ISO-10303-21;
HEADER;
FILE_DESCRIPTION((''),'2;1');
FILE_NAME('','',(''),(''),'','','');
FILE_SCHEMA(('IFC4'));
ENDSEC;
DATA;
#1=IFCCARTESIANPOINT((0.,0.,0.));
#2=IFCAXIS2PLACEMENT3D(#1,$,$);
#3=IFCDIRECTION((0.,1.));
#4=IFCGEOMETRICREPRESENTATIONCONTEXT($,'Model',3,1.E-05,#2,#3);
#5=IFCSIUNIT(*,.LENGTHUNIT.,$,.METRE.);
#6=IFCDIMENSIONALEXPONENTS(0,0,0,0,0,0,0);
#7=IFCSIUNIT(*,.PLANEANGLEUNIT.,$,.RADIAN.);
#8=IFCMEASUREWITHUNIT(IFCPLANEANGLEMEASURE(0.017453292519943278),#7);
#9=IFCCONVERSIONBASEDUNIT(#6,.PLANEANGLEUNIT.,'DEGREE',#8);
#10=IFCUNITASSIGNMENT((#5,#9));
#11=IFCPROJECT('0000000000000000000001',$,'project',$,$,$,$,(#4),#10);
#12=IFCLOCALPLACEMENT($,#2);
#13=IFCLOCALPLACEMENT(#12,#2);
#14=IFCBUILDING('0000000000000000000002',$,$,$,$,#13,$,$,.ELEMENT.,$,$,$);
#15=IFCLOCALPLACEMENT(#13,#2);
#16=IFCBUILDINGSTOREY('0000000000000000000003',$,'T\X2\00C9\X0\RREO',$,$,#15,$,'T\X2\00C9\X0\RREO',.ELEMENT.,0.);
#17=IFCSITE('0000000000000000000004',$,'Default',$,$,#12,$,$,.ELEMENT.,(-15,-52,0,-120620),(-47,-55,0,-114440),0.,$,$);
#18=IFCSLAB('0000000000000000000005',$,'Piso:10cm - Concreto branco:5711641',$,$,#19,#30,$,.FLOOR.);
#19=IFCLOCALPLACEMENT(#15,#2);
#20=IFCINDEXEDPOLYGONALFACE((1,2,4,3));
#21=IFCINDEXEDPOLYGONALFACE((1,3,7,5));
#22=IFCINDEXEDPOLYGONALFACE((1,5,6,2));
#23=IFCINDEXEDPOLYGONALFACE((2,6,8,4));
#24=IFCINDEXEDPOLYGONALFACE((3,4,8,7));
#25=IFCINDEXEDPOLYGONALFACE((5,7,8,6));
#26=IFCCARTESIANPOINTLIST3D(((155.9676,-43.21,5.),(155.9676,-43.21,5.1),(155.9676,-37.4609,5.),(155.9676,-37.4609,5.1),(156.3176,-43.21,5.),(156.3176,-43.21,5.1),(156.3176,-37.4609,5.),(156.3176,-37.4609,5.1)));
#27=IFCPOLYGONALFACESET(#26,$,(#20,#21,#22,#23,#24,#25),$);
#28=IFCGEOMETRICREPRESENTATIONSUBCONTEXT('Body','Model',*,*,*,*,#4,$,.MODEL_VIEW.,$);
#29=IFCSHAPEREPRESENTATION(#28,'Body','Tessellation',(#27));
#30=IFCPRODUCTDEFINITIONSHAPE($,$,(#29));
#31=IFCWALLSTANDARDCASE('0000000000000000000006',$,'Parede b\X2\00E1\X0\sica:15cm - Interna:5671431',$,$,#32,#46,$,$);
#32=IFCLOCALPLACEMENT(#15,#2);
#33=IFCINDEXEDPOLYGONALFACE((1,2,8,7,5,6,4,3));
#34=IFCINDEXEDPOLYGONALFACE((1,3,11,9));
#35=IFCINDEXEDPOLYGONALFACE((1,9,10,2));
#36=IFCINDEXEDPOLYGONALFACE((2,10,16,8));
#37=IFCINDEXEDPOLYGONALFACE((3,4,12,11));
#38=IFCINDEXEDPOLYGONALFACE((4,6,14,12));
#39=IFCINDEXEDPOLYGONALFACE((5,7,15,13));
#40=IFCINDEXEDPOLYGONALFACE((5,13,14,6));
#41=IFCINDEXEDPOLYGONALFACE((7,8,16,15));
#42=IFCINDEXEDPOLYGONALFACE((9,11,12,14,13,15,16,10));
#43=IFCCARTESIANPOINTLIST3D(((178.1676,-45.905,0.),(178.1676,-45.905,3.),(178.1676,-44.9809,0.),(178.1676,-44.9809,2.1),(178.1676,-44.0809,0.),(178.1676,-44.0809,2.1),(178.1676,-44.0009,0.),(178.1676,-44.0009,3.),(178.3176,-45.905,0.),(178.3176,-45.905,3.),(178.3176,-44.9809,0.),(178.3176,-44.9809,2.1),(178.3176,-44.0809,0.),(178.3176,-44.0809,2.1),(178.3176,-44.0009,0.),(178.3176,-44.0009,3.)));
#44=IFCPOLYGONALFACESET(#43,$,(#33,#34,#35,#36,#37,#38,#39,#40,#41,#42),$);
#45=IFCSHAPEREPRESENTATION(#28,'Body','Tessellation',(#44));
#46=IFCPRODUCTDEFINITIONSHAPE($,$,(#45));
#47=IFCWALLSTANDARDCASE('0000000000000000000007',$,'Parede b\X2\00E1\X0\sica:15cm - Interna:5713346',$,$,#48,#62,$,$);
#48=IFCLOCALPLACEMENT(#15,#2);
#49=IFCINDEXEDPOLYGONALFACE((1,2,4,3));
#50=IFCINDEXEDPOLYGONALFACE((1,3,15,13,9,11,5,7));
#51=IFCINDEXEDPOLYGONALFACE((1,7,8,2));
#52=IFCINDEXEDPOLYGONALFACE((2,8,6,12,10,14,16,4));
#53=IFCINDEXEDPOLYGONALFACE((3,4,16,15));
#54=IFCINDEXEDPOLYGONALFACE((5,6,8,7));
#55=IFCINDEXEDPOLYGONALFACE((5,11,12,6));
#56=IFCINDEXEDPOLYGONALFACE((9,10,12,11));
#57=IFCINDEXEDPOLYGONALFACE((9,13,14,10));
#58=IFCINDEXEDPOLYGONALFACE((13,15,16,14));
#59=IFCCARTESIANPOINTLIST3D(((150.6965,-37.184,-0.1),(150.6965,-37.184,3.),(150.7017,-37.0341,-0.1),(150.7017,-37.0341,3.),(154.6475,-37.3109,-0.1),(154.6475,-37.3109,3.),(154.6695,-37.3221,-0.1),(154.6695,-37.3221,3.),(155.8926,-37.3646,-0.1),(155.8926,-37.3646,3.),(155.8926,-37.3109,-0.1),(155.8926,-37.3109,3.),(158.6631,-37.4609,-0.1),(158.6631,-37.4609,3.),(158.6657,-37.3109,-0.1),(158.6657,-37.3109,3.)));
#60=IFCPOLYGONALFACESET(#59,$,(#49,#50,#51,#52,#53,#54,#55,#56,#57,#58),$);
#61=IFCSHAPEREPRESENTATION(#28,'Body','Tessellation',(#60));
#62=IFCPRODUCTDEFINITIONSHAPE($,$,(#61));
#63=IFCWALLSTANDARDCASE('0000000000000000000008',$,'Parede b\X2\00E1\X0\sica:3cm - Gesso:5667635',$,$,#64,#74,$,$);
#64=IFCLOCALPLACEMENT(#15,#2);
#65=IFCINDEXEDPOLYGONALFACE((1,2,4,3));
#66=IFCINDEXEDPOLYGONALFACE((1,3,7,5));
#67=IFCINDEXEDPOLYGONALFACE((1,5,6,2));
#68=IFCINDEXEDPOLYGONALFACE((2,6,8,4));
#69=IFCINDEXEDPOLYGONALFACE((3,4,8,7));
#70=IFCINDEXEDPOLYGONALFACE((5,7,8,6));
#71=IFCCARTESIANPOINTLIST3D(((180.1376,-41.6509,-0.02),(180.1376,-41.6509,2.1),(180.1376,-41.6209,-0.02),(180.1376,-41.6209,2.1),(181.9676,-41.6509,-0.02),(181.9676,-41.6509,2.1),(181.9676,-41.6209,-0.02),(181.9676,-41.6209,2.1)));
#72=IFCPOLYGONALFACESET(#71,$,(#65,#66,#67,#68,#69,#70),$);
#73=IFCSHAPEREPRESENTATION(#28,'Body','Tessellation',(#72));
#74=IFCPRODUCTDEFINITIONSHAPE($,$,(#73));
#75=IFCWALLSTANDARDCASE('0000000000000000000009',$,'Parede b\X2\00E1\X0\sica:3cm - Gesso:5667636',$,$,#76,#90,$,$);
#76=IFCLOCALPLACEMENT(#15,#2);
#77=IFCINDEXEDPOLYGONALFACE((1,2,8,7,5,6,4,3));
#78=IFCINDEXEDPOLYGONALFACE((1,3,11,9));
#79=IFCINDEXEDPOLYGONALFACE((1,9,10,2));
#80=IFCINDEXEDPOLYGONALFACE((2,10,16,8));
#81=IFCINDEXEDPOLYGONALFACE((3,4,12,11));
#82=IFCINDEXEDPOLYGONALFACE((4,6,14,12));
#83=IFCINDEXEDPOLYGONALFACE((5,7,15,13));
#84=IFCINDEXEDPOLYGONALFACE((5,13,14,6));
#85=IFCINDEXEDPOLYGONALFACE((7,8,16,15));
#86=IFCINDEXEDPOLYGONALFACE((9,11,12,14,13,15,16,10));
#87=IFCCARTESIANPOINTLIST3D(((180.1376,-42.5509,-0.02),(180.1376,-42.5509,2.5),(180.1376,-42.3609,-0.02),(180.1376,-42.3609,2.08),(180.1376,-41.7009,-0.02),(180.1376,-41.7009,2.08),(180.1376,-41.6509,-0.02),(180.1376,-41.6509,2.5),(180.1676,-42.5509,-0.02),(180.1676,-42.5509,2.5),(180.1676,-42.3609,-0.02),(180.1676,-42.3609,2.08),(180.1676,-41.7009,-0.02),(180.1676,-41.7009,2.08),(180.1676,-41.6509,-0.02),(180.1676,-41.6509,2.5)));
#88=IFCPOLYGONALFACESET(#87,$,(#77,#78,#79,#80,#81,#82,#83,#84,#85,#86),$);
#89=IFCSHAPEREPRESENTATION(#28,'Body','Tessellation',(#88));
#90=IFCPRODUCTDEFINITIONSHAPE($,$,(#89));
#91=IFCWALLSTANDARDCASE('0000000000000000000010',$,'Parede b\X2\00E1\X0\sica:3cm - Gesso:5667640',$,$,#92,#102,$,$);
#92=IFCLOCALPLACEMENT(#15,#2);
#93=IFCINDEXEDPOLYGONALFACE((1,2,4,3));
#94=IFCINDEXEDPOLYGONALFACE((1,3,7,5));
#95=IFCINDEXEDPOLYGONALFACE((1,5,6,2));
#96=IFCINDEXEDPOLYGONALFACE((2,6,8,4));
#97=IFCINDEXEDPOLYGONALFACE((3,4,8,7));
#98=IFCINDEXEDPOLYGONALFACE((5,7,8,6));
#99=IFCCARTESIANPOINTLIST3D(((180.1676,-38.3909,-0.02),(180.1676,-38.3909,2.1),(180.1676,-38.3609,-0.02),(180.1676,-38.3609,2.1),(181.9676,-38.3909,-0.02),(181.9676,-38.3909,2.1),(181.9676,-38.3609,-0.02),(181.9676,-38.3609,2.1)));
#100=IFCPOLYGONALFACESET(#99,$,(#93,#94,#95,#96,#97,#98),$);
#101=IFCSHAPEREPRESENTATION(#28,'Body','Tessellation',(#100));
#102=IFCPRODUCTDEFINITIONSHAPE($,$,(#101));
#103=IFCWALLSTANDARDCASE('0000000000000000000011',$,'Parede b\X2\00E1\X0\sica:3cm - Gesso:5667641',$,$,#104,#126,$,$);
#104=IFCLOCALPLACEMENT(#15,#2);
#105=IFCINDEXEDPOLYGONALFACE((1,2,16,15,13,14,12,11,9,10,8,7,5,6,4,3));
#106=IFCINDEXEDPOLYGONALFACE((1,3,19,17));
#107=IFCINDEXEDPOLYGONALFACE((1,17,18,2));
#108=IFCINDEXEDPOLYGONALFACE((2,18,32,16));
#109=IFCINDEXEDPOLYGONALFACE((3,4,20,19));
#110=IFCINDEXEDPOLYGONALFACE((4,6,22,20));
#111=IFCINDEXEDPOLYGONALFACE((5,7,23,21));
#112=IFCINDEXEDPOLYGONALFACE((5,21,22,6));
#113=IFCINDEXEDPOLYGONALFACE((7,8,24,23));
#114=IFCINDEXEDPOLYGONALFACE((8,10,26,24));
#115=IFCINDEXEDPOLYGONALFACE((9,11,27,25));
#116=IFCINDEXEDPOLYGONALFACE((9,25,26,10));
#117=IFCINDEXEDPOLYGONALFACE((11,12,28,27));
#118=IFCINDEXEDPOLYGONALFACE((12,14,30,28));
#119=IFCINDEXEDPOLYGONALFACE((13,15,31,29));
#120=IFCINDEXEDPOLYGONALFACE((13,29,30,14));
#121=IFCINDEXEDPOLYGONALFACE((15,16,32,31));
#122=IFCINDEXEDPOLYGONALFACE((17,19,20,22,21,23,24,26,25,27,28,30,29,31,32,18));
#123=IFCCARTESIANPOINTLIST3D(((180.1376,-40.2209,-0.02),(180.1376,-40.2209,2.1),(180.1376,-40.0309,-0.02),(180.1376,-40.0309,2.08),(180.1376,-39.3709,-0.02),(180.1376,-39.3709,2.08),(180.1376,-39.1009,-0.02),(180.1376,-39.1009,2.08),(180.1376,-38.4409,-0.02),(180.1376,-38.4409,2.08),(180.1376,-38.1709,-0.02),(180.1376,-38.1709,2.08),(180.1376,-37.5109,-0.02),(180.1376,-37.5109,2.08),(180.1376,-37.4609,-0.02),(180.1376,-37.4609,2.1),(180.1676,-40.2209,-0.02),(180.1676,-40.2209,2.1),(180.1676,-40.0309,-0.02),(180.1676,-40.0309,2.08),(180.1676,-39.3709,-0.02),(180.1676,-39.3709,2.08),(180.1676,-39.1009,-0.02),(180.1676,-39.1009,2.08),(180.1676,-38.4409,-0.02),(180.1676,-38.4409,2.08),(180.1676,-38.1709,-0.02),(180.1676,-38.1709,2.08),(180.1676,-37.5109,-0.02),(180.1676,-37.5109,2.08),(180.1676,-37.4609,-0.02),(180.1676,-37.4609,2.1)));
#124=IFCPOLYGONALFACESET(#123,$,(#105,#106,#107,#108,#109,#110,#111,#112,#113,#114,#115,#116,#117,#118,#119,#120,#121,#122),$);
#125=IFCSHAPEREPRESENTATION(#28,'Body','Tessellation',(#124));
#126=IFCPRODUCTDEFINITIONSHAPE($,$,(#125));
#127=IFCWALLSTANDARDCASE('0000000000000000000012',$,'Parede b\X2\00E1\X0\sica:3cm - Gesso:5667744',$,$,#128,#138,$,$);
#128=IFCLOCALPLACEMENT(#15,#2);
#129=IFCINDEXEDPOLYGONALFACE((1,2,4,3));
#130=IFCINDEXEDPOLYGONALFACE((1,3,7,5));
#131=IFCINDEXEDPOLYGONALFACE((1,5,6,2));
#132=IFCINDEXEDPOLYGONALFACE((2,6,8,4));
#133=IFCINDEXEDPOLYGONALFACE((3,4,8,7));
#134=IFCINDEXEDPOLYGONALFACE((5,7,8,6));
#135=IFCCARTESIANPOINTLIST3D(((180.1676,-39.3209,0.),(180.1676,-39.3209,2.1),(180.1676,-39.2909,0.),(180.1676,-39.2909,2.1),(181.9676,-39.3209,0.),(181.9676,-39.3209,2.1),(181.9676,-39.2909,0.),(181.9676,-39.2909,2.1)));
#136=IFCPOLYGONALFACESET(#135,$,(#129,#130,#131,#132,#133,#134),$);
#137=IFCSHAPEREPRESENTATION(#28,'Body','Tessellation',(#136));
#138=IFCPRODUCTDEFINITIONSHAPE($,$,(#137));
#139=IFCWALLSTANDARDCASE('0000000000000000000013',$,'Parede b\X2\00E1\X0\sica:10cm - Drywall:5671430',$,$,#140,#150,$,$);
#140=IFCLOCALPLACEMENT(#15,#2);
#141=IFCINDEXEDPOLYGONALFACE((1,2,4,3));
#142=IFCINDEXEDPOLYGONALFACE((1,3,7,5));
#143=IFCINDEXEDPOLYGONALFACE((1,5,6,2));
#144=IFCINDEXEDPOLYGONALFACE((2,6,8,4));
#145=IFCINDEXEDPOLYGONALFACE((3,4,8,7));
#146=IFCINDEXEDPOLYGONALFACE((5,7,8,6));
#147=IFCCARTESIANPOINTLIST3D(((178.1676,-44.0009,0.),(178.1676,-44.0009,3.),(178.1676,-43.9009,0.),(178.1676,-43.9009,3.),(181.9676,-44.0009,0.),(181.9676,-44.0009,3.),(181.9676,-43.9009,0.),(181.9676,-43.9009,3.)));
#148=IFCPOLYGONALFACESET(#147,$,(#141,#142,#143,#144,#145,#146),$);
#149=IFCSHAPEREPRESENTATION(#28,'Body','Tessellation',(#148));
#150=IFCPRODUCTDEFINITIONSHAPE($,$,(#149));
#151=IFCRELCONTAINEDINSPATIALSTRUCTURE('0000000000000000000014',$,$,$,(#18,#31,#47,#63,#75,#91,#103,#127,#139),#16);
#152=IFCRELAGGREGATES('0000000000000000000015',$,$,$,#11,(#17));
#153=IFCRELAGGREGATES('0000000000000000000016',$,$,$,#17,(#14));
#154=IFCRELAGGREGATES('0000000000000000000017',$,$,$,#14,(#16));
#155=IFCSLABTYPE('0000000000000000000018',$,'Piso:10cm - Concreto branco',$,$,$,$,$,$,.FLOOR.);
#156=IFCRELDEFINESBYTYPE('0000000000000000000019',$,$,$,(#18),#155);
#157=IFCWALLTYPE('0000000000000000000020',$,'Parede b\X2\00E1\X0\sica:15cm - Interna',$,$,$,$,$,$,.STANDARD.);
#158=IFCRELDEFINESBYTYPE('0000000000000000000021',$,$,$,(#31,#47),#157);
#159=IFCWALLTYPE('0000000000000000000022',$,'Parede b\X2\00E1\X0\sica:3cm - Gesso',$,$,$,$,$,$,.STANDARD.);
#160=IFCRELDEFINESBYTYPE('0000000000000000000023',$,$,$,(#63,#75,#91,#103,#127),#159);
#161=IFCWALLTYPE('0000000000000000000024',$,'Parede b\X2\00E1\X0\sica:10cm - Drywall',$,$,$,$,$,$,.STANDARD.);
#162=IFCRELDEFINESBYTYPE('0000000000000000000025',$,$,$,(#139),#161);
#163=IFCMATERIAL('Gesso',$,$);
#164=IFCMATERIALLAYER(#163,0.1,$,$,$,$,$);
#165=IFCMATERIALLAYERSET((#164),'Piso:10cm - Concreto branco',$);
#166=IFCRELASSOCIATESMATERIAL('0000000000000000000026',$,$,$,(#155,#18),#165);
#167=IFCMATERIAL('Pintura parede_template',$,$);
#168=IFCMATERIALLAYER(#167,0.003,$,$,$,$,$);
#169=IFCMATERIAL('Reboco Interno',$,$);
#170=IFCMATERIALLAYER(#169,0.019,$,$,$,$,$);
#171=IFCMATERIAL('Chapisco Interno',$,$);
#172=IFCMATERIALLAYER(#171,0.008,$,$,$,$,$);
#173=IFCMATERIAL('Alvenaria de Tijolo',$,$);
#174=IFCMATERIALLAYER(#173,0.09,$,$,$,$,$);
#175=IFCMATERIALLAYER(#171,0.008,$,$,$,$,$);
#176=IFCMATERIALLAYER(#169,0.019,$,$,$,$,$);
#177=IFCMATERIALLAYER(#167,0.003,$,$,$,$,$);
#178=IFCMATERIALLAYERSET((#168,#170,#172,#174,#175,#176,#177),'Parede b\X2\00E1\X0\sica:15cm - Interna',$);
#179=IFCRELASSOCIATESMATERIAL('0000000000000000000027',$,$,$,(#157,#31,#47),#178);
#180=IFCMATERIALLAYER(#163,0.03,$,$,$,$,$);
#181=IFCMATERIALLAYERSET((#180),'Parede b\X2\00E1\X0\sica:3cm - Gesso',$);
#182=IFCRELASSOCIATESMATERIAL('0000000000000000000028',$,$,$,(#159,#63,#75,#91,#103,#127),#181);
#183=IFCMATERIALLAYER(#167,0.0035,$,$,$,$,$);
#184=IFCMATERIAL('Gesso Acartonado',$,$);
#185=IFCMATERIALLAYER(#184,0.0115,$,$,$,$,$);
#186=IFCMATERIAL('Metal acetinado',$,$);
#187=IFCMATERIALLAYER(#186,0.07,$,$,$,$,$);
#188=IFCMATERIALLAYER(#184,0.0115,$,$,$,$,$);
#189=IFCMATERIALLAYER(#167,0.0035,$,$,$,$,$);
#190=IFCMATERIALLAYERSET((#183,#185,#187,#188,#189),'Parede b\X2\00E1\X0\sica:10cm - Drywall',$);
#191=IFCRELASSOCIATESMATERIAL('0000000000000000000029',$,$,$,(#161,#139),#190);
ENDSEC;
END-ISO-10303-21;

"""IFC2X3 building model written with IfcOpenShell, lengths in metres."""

from ifc_helpers import new_model, entity, si_unit, converted_unit, direction, frame, frame_2d, origin, place, context, subcontext, project, spatial, polyline, rectangle, outline, extrude, material, layer, layer_set, layer_usage, type_object, element, save


model = new_model("IFC2X3")

# Units and contexts
model_context = context("Model", 3, precision=1e-05, world=origin(), true_north=direction((0.0, 1.0)))
body_context = subcontext(model_context, "Body", "Model", "MODEL_VIEW")
ifc_project = project(units=[si_unit("LENGTHUNIT", "METRE"), converted_unit("PLANEANGLEUNIT", "DEGREE", entity("IfcPlaneAngleMeasure", 0.017453292519943278), si_unit("PLANEANGLEUNIT", "RADIAN"), dimensions=[0, 0, 0, 0, 0, 0, 0])], contexts=[model_context])

# Site, building, storey
site_placement = place(None, origin())
site = spatial("IfcSite", under=ifc_project, at=site_placement, Name="Default", CompositionType="ELEMENT", RefLatitude=(-15, -52, 0, -120620), RefLongitude=(-47, -55, 0, -114440), RefElevation=0.0)
building_placement = place(site_placement, origin())
building = spatial("IfcBuilding", under=site, at=building_placement, CompositionType="ELEMENT")
storey_placement = place(building_placement, origin())
storey = spatial("IfcBuildingStorey", under=building, at=storey_placement, Name="TÉRREO", LongName="TÉRREO", CompositionType="ELEMENT", Elevation=0.0)

# Slab
ifc_material_1 = material(Name="Gesso")
ifc_layer_1 = layer(ifc_material_1, 0.1)
ifc_layer_set_1 = layer_set([ifc_layer_1], Name="Piso:10cm - Concreto branco")
ifc_layer_usage_1 = layer_usage(ifc_layer_set_1, "AXIS3", "POSITIVE", 0.0)
slab_type_1 = type_object("IfcSlabType", Name="Piso:10cm - Concreto branco", PredefinedType="FLOOR", material=ifc_layer_set_1)
slab_1_placement = place(storey_placement, origin())
element("IfcSlab", 1, at=slab_1_placement, inside=storey, type_object=slab_type_1, material=ifc_layer_usage_1, Name="Piso:10cm - Concreto branco:5711641", PredefinedType="FLOOR", context=body_context, shape_type="SweptSolid", body=[
    extrude(rectangle(XDim=5.7491, YDim=0.35, at=frame_2d((0.0, 0.0), x_axis=(1.0, 0.0))), frame((156.1426, -40.3355, 5.1), z_axis=(0.0, 0.0, -1.0), x_axis=(0.0, 1.0, 0.0)), (0.0, 0.0, 1.0), 0.1),
])

# Wall, opening
ifc_material_2 = material(Name="Pintura parede_template")
ifc_layer_2 = layer(ifc_material_2, 0.003)
ifc_material_3 = material(Name="Reboco Interno")
ifc_layer_3 = layer(ifc_material_3, 0.019)
ifc_material_4 = material(Name="Chapisco Interno")
ifc_layer_4 = layer(ifc_material_4, 0.008)
ifc_material_5 = material(Name="Alvenaria de Tijolo")
ifc_layer_5 = layer(ifc_material_5, 0.09)
ifc_layer_6 = layer(ifc_material_4, 0.008)
ifc_layer_7 = layer(ifc_material_3, 0.019)
ifc_layer_8 = layer(ifc_material_2, 0.003)
ifc_layer_set_2 = layer_set([ifc_layer_2, ifc_layer_3, ifc_layer_4, ifc_layer_5, ifc_layer_6, ifc_layer_7, ifc_layer_8], Name="Parede básica:15cm - Interna")
ifc_layer_usage_2 = layer_usage(ifc_layer_set_2, "AXIS2", "POSITIVE", -0.075)
wall_type_1 = type_object("IfcWallType", Name="Parede básica:15cm - Interna", PredefinedType="STANDARD", material=ifc_layer_set_2)
wall_1_placement = place(storey_placement, frame((178.2426, -44.0009, 0.0), z_axis=(0.0, 0.0, 1.0), x_axis=(0.0, -1.0, 0.0)))
wall_1 = element("IfcWallStandardCase", 2, at=wall_1_placement, inside=storey, type_object=wall_type_1, material=ifc_layer_usage_2, Name="Parede básica:15cm - Interna:5671431", context=body_context, shape_type="SweptSolid", body=[
    extrude(rectangle(XDim=1.9041, YDim=0.15, at=frame_2d((0.9521, 0.0), x_axis=(-1.0, 0.0))), origin(), (0.0, 0.0, 1.0), 3.0),
])
opening_1_placement = place(wall_1_placement, frame((0.08, -0.075, 0.0)))
element("IfcOpeningElement", 3, at=opening_1_placement, cuts=wall_1, ObjectType="Opening", context=body_context, shape_type="SweptSolid", body=[
    extrude(rectangle(XDim=0.9, YDim=2.1, at=frame_2d((1.05, 0.45), x_axis=(0.0, -1.0))), frame((0.0, 0.0, 0.0), z_axis=(0.0, 1.0, 0.0), x_axis=(0.0, 0.0, 1.0)), (0.0, 0.0, 1.0), 0.15),
])

# Walls
ifc_layer_usage_3 = layer_usage(ifc_layer_set_2, "AXIS2", "NEGATIVE", 0.075)
wall_2_placement = place(storey_placement, frame((150.6991, -37.1091, -0.1), z_axis=(0.0, 0.0, 1.0), x_axis=(0.999397, -0.034732, 0.0)))
element("IfcWallStandardCase", 4, at=wall_2_placement, inside=storey, type_object=wall_type_1, material=ifc_layer_usage_3, Name="Parede básica:15cm - Interna:5713346", context=body_context, shape_type="SweptSolid", body=[
    extrude(outline(polyline([(0.0, 0.075), (0.0, -0.075), (3.9754, -0.075), (3.9531, -0.0646), (5.1973, -0.0213), (5.1992, -0.075), (7.9714, -0.075), (7.9688, 0.075), (0.0, 0.075)])), origin(), (0.0, 0.0, 1.0), 3.1),
])
ifc_layer_9 = layer(ifc_material_1, 0.03)
ifc_layer_set_3 = layer_set([ifc_layer_9], Name="Parede básica:3cm - Gesso")
ifc_layer_usage_4 = layer_usage(ifc_layer_set_3, "AXIS2", "NEGATIVE", 0.015)
wall_type_2 = type_object("IfcWallType", Name="Parede básica:3cm - Gesso", PredefinedType="STANDARD", material=ifc_layer_set_3)
wall_3_placement = place(storey_placement, frame((181.9676, -41.6359, -0.02), z_axis=(0.0, 0.0, 1.0), x_axis=(-1.0, 0.0, 0.0)))
element("IfcWallStandardCase", 5, at=wall_3_placement, inside=storey, type_object=wall_type_2, material=ifc_layer_usage_4, Name="Parede básica:3cm - Gesso:5667635", context=body_context, shape_type="SweptSolid", body=[
    extrude(rectangle(XDim=1.83, YDim=0.03, at=frame_2d((0.915, 0.0), x_axis=(-1.0, 0.0))), origin(), (0.0, 0.0, 1.0), 2.12),
])

# Wall, opening
ifc_layer_usage_5 = layer_usage(ifc_layer_set_3, "AXIS2", "NEGATIVE", 0.015)
wall_4_placement = place(storey_placement, frame((180.1526, -42.5509, -0.02), z_axis=(0.0, 0.0, 1.0), x_axis=(0.0, 1.0, 0.0)))
wall_4 = element("IfcWallStandardCase", 6, at=wall_4_placement, inside=storey, type_object=wall_type_2, material=ifc_layer_usage_5, Name="Parede básica:3cm - Gesso:5667636", context=body_context, shape_type="SweptSolid", body=[
    extrude(rectangle(XDim=0.9, YDim=0.03, at=frame_2d((0.45, 0.0), x_axis=(-1.0, 0.0))), origin(), (0.0, 0.0, 1.0), 2.52),
])
opening_2_placement = place(wall_4_placement, frame((0.85, 0.015, 0.0)))
element("IfcOpeningElement", 7, at=opening_2_placement, cuts=wall_4, ObjectType="Opening", context=body_context, shape_type="SweptSolid", body=[
    extrude(rectangle(XDim=0.66, YDim=2.1, at=frame_2d((1.05, 0.33), x_axis=(0.0, -1.0))), frame((0.0, 0.0, 0.0), z_axis=(0.0, -1.0, 0.0), x_axis=(0.0, 0.0, 1.0)), (0.0, 0.0, 1.0), 0.03),
])

# Wall
ifc_layer_usage_6 = layer_usage(ifc_layer_set_3, "AXIS2", "POSITIVE", -0.015)
wall_5_placement = place(storey_placement, frame((181.9676, -38.3759, -0.02), z_axis=(0.0, 0.0, 1.0), x_axis=(-1.0, 0.0, 0.0)))
element("IfcWallStandardCase", 8, at=wall_5_placement, inside=storey, type_object=wall_type_2, material=ifc_layer_usage_6, Name="Parede básica:3cm - Gesso:5667640", context=body_context, shape_type="SweptSolid", body=[
    extrude(rectangle(XDim=1.8, YDim=0.03, at=frame_2d((0.9, 0.0), x_axis=(-1.0, 0.0))), origin(), (0.0, 0.0, 1.0), 2.12),
])

# Wall, openings
ifc_layer_usage_7 = layer_usage(ifc_layer_set_3, "AXIS2", "POSITIVE", -0.015)
wall_6_placement = place(storey_placement, frame((180.1526, -37.4609, -0.02), z_axis=(0.0, 0.0, 1.0), x_axis=(0.0, -1.0, 0.0)))
wall_6 = element("IfcWallStandardCase", 9, at=wall_6_placement, inside=storey, type_object=wall_type_2, material=ifc_layer_usage_7, Name="Parede básica:3cm - Gesso:5667641", context=body_context, shape_type="SweptSolid", body=[
    extrude(rectangle(XDim=2.76, YDim=0.03, at=frame_2d((1.38, 0.0), x_axis=(-1.0, 0.0))), origin(), (0.0, 0.0, 1.0), 2.12),
])
opening_3_placement = place(wall_6_placement, frame((0.98, -0.015, 0.0)))
element("IfcOpeningElement", 10, at=opening_3_placement, cuts=wall_6, ObjectType="Opening", context=body_context, shape_type="SweptSolid", body=[
    extrude(rectangle(XDim=0.66, YDim=2.1, at=frame_2d((1.05, 0.33), x_axis=(0.0, -1.0))), frame((0.0, 0.0, 0.0), z_axis=(0.0, 1.0, 0.0), x_axis=(0.0, 0.0, 1.0)), (0.0, 0.0, 1.0), 0.03),
])
opening_4_placement = place(wall_6_placement, frame((0.05, -0.015, 0.0)))
element("IfcOpeningElement", 11, at=opening_4_placement, cuts=wall_6, ObjectType="Opening", context=body_context, shape_type="SweptSolid", body=[
    extrude(rectangle(XDim=0.66, YDim=2.1, at=frame_2d((1.05, 0.33), x_axis=(0.0, -1.0))), frame((0.0, 0.0, 0.0), z_axis=(0.0, 1.0, 0.0), x_axis=(0.0, 0.0, 1.0)), (0.0, 0.0, 1.0), 0.03),
])
opening_5_placement = place(wall_6_placement, frame((1.91, -0.015, 0.0)))
element("IfcOpeningElement", 12, at=opening_5_placement, cuts=wall_6, ObjectType="Opening", context=body_context, shape_type="SweptSolid", body=[
    extrude(rectangle(XDim=0.66, YDim=2.1, at=frame_2d((1.05, 0.33), x_axis=(0.0, -1.0))), frame((0.0, 0.0, 0.0), z_axis=(0.0, 1.0, 0.0), x_axis=(0.0, 0.0, 1.0)), (0.0, 0.0, 1.0), 0.03),
])

# Walls
ifc_layer_usage_8 = layer_usage(ifc_layer_set_3, "AXIS2", "NEGATIVE", 0.015)
wall_7_placement = place(storey_placement, frame((180.1676, -39.3059, 0.0)))
element("IfcWallStandardCase", 13, at=wall_7_placement, inside=storey, type_object=wall_type_2, material=ifc_layer_usage_8, Name="Parede básica:3cm - Gesso:5667744", context=body_context, shape_type="SweptSolid", body=[
    extrude(rectangle(XDim=1.8, YDim=0.03, at=frame_2d((0.9, 0.0), x_axis=(-1.0, 0.0))), origin(), (0.0, 0.0, 1.0), 2.1),
])
ifc_layer_10 = layer(ifc_material_2, 0.0035)
ifc_material_6 = material(Name="Gesso Acartonado")
ifc_layer_11 = layer(ifc_material_6, 0.0115)
ifc_material_7 = material(Name="Metal acetinado")
ifc_layer_12 = layer(ifc_material_7, 0.07)
ifc_layer_13 = layer(ifc_material_6, 0.0115)
ifc_layer_14 = layer(ifc_material_2, 0.0035)
ifc_layer_set_4 = layer_set([ifc_layer_10, ifc_layer_11, ifc_layer_12, ifc_layer_13, ifc_layer_14], Name="Parede básica:10cm - Drywall")
ifc_layer_usage_9 = layer_usage(ifc_layer_set_4, "AXIS2", "NEGATIVE", 0.05)
wall_type_3 = type_object("IfcWallType", Name="Parede básica:10cm - Drywall", PredefinedType="STANDARD", material=ifc_layer_set_4)
wall_8_placement = place(storey_placement, frame((178.1676, -43.9509, 0.0)))
element("IfcWallStandardCase", 14, at=wall_8_placement, inside=storey, type_object=wall_type_3, material=ifc_layer_usage_9, Name="Parede básica:10cm - Drywall:5671430", context=body_context, shape_type="SweptSolid", body=[
    extrude(rectangle(XDim=3.8, YDim=0.1, at=frame_2d((1.9, 0.0), x_axis=(-1.0, 0.0))), origin(), (0.0, 0.0, 1.0), 3.0),
])

save(model, "model.ifc")
